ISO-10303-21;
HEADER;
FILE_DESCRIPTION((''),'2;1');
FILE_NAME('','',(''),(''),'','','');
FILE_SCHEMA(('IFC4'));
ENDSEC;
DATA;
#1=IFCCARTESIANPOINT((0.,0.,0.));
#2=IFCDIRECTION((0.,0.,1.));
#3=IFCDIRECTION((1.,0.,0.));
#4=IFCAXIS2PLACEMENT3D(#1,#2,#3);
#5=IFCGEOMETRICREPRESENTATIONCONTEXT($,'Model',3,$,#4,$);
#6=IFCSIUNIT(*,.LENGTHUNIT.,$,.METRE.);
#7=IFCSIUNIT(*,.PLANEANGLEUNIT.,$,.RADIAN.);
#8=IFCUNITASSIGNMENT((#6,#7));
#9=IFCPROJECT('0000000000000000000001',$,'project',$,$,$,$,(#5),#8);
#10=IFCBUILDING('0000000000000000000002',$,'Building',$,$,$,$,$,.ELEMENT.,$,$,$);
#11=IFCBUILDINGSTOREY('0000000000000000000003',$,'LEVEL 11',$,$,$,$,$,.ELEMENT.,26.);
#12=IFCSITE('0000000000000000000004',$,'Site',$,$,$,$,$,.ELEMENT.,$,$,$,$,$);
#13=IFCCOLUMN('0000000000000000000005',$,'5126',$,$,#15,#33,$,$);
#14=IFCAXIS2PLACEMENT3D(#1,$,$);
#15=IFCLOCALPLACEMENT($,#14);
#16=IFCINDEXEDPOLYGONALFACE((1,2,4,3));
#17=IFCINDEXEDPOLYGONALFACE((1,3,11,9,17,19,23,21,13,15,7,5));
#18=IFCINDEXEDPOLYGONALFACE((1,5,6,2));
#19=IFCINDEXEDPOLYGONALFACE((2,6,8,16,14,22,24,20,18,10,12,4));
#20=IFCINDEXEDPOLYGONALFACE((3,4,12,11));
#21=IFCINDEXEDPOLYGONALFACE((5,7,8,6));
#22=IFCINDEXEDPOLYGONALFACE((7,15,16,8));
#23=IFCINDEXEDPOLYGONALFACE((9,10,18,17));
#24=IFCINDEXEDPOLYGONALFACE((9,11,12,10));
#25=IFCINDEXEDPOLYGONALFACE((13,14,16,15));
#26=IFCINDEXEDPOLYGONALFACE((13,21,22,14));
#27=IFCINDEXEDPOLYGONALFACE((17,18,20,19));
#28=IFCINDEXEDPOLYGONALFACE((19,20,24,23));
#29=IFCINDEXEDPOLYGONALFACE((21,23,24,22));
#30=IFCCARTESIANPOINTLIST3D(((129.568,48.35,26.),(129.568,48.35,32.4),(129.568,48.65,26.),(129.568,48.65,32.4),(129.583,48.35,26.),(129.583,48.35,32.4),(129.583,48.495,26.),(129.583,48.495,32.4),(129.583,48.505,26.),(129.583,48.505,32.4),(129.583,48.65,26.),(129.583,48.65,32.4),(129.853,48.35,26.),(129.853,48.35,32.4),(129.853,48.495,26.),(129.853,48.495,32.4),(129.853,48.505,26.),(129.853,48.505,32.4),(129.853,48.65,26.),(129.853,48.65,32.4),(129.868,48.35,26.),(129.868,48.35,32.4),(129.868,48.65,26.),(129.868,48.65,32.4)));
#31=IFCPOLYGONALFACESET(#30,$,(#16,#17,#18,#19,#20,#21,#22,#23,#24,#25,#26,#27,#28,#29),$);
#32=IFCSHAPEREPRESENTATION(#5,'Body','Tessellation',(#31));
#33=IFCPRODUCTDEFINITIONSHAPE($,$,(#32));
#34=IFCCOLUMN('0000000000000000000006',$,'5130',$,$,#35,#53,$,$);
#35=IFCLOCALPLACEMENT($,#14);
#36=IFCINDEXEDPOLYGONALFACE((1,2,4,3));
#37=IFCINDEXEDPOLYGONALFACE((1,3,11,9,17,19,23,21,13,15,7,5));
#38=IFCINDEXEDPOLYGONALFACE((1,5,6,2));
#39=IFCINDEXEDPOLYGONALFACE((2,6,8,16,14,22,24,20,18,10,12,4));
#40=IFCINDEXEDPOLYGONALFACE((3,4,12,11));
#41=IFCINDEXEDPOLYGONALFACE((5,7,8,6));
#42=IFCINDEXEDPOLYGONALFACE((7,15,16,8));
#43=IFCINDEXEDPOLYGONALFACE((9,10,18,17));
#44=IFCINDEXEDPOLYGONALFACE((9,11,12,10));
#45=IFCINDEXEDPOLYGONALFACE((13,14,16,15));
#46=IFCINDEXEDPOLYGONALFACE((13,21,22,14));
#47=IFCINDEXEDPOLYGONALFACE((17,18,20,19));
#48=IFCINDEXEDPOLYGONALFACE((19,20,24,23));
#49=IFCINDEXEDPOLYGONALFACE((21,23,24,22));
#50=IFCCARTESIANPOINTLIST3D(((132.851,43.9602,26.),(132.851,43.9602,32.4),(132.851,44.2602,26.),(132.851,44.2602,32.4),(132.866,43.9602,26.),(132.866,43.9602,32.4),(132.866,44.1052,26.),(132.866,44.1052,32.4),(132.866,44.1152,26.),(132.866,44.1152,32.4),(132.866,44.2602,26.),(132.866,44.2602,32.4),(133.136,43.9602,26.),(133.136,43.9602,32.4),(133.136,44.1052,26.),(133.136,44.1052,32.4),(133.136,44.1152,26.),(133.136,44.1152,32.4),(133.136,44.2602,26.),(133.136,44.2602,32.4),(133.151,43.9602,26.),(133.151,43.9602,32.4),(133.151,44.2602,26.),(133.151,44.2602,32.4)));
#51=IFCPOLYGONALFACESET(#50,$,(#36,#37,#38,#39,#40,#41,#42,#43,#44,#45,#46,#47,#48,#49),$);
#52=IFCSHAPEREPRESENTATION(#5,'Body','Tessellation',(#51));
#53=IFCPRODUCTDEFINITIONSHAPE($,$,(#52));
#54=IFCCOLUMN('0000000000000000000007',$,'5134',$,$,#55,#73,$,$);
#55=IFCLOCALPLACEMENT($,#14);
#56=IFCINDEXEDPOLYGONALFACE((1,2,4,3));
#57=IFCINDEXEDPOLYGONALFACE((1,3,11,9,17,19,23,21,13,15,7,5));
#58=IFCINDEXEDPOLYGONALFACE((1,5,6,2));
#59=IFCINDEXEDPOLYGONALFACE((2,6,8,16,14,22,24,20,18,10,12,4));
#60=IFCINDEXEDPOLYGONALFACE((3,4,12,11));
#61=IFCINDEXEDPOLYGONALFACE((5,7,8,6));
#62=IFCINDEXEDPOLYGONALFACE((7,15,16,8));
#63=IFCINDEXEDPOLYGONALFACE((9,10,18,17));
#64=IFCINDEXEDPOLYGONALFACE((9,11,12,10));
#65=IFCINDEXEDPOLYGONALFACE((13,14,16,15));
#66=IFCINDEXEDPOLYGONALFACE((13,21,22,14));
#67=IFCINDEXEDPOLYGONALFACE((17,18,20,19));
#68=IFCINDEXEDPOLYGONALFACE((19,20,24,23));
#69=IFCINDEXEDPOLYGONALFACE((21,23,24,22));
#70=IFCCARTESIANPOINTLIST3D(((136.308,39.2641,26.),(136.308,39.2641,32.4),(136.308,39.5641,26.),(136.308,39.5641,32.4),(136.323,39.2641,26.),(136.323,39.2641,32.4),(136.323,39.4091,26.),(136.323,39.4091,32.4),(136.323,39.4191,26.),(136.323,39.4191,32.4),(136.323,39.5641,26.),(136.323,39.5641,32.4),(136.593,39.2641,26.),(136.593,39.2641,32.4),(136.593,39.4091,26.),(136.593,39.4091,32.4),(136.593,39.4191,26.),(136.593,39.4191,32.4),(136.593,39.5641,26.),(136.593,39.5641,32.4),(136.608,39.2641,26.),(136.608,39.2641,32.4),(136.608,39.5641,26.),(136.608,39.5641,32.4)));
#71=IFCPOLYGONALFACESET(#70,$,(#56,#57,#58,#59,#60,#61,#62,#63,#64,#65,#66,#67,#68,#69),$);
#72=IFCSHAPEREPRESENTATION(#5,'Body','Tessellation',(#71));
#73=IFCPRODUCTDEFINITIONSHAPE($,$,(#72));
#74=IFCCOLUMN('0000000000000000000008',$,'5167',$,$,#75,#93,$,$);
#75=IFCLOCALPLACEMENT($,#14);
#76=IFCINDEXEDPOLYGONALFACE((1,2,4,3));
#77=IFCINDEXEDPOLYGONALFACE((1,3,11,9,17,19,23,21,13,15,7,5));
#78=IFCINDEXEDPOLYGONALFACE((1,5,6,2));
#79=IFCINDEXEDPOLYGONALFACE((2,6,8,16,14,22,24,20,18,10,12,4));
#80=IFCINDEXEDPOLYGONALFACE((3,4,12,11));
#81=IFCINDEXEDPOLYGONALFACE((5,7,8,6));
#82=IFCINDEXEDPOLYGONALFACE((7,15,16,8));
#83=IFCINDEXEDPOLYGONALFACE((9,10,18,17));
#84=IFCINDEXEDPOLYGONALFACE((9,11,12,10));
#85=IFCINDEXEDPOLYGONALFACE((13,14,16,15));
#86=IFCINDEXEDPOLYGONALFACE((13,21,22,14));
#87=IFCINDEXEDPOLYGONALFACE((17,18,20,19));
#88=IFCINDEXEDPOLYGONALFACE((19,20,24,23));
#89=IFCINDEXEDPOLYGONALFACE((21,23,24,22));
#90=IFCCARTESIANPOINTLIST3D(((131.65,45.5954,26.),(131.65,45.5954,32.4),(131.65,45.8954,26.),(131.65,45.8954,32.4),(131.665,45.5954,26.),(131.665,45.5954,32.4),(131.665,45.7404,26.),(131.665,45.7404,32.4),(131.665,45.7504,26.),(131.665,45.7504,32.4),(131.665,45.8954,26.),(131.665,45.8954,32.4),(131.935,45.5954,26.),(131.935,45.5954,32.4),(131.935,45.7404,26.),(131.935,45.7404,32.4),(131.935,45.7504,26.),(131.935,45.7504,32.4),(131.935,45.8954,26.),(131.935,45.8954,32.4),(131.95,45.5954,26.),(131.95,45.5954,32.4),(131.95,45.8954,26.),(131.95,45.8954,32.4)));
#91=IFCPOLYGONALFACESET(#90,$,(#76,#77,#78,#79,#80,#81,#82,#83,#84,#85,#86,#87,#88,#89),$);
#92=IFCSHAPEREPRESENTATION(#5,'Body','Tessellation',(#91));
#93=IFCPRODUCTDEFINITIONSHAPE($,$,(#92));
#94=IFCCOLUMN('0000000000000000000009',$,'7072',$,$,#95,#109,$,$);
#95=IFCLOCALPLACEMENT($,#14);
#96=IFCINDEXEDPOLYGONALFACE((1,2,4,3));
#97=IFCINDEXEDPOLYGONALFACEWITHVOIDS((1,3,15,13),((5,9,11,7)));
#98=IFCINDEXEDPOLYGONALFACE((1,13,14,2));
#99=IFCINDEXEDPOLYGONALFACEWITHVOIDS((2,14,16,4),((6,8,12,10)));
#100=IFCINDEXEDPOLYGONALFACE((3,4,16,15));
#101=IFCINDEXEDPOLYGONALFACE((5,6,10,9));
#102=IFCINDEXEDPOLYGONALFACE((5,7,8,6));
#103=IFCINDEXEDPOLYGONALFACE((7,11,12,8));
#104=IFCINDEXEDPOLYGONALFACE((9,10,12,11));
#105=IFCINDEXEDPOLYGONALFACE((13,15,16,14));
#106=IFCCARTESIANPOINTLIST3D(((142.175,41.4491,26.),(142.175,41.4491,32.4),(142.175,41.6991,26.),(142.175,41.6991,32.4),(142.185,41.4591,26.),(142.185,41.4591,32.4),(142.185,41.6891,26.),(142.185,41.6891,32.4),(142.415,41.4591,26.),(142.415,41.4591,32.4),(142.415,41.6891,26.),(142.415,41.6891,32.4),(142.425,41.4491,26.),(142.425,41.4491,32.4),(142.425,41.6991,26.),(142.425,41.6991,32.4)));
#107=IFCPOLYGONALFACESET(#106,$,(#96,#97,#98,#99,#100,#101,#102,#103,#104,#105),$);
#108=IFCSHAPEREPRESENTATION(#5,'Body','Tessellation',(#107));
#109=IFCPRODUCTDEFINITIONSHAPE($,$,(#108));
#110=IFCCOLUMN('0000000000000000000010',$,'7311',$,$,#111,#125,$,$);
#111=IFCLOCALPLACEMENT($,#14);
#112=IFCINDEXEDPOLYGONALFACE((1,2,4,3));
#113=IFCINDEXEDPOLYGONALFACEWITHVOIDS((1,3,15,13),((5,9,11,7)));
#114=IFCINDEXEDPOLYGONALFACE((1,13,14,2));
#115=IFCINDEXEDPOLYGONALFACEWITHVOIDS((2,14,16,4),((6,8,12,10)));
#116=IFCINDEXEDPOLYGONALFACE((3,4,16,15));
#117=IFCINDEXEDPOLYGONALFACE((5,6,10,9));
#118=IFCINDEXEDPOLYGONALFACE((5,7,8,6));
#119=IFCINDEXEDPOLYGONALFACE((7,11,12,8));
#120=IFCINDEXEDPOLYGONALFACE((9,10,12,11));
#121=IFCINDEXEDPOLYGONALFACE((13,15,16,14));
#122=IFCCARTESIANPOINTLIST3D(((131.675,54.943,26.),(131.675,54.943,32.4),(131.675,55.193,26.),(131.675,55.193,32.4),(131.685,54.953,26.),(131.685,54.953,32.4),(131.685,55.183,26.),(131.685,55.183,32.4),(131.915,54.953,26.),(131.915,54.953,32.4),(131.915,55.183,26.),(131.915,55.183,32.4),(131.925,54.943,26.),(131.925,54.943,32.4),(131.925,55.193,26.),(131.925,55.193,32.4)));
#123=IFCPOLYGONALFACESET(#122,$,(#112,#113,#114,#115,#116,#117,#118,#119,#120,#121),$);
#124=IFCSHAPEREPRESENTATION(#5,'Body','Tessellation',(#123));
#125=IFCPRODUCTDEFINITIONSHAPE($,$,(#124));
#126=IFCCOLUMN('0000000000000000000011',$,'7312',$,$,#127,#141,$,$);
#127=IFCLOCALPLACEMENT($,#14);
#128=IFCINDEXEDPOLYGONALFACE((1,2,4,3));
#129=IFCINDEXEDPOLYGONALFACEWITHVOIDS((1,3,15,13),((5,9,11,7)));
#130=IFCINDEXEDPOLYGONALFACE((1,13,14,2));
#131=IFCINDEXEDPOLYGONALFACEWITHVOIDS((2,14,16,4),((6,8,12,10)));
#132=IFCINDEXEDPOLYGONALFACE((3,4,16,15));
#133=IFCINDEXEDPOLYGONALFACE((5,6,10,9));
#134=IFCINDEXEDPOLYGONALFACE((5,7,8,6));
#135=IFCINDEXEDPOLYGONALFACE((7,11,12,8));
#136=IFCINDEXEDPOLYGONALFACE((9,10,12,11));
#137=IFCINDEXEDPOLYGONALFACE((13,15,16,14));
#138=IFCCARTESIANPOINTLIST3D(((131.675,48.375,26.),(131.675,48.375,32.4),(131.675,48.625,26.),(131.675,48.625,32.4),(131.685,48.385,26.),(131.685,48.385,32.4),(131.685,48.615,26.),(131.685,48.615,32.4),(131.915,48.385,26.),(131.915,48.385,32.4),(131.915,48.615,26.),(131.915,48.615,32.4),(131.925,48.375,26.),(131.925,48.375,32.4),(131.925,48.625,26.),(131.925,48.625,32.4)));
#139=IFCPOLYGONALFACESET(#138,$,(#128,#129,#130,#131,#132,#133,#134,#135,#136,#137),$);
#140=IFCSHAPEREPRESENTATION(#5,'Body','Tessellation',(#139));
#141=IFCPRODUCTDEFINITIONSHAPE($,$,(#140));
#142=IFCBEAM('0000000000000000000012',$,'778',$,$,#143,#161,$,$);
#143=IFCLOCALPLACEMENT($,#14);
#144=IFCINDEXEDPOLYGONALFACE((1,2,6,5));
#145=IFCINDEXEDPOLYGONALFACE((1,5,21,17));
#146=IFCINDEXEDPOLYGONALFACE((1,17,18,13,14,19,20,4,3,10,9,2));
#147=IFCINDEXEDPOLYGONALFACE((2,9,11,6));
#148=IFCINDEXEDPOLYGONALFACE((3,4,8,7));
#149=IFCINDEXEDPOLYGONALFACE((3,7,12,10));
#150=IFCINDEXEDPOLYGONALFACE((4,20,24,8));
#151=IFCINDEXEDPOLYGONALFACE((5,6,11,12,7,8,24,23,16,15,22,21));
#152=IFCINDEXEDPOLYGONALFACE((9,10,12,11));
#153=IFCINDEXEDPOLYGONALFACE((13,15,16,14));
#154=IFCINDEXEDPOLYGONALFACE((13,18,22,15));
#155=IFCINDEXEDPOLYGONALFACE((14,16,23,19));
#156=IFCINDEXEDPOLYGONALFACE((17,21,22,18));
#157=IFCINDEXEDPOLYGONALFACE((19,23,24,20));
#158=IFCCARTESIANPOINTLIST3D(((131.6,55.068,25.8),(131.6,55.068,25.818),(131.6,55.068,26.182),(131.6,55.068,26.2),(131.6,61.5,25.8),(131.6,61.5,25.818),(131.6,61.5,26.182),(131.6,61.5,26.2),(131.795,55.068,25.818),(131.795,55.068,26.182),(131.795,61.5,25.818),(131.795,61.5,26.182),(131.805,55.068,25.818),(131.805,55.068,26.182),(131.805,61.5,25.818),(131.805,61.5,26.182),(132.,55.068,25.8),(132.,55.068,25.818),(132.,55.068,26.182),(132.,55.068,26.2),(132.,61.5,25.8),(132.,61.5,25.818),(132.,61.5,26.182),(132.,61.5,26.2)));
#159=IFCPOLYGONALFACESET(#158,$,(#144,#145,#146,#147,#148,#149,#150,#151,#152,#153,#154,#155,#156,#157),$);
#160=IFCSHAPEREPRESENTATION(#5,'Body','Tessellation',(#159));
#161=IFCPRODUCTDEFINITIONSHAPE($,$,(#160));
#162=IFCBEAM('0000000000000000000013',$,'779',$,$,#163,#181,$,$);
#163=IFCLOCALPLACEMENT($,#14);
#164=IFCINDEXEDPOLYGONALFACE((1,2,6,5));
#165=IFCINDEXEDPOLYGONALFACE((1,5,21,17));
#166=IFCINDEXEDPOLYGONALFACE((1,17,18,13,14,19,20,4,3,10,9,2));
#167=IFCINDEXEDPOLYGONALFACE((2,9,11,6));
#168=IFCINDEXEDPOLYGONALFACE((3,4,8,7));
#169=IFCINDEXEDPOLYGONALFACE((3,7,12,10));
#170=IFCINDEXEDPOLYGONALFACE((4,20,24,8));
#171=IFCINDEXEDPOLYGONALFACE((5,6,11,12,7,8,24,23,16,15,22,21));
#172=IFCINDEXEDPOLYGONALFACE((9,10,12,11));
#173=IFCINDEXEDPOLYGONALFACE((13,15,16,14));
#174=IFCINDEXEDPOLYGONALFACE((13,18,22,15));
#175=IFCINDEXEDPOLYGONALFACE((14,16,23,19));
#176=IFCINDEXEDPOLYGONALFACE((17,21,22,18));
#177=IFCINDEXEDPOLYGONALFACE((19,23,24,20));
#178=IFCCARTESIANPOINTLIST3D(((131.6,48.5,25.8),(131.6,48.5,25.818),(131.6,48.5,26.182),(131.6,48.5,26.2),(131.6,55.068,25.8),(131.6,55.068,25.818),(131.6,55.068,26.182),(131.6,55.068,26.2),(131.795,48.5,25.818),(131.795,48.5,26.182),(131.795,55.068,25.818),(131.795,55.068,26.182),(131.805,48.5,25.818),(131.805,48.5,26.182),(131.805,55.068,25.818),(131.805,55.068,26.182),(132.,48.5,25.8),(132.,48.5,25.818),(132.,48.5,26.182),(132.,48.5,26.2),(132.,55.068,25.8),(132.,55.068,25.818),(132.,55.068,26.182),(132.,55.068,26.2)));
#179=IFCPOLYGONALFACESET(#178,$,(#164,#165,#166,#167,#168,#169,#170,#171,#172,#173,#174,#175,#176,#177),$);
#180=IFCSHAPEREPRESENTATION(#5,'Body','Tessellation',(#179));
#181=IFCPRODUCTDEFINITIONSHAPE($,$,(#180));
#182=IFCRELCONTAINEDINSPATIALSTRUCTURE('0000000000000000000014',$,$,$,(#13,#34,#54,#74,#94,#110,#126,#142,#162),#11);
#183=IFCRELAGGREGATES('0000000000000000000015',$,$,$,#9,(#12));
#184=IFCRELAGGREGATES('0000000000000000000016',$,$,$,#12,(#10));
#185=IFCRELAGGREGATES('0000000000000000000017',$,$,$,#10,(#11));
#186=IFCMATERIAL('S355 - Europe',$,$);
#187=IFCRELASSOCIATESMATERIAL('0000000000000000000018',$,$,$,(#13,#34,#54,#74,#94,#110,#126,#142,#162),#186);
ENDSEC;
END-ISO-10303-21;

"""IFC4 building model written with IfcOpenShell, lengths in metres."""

from ifc_helpers import new_model, si_unit, frame, origin_with_axes, origin_2d_with_axis, place, context, project, spatial, hollow_rectangle, i_section, extrude, material, material_profile, profile_set, profile_usage, element, save


model = new_model("IFC4")

# Units and contexts
model_context = context("Model", 3, world=origin_with_axes())
ifc_project = project(units=[si_unit("LENGTHUNIT", "METRE"), si_unit("PLANEANGLEUNIT", "RADIAN")], contexts=[model_context])

# Site, building, storey
site = spatial("IfcSite", under=ifc_project, Name="Site", CompositionType="ELEMENT")
building = spatial("IfcBuilding", under=site, Name="Building", CompositionType="ELEMENT")
storey = spatial("IfcBuildingStorey", under=building, Name="LEVEL 11", CompositionType="ELEMENT", Elevation=26.0)

# Columns
ifc_material = material(Name="S355 - Europe")
ifc_material_profile_1 = material_profile(ifc_material, i_section(OverallWidth=0.3, OverallDepth=0.3, WebThickness=0.01, FlangeThickness=0.015, at=origin_2d_with_axis()))
ifc_profile_set_1 = profile_set([ifc_material_profile_1])
ifc_profile_usage_1 = profile_usage(ifc_profile_set_1, cardinal=10)
column_1_placement = place(None, frame((129.718, 48.5, 26.0), z_axis=(0.0, 0.0, 1.0), x_axis=(0.0, -1.0, 0.0)))
element("IfcColumn", 1, at=column_1_placement, inside=storey, material=ifc_profile_usage_1, Name="5126", context=model_context, shape_type="SweptSolid", body=[
    extrude(i_section(OverallWidth=0.3, OverallDepth=0.3, WebThickness=0.01, FlangeThickness=0.015, at=origin_2d_with_axis()), origin_with_axes(), (0.0, 0.0, 1.0), 6.4),
])
ifc_material_profile_2 = material_profile(ifc_material, i_section(OverallWidth=0.3, OverallDepth=0.3, WebThickness=0.01, FlangeThickness=0.015, at=origin_2d_with_axis()))
ifc_profile_set_2 = profile_set([ifc_material_profile_2])
ifc_profile_usage_2 = profile_usage(ifc_profile_set_2, cardinal=10)
column_2_placement = place(None, frame((133.001, 44.1102, 26.0), z_axis=(0.0, 0.0, 1.0), x_axis=(0.0, -1.0, 0.0)))
element("IfcColumn", 2, at=column_2_placement, inside=storey, material=ifc_profile_usage_2, Name="5130", context=model_context, shape_type="SweptSolid", body=[
    extrude(i_section(OverallWidth=0.3, OverallDepth=0.3, WebThickness=0.01, FlangeThickness=0.015, at=origin_2d_with_axis()), origin_with_axes(), (0.0, 0.0, 1.0), 6.4),
])
ifc_material_profile_3 = material_profile(ifc_material, i_section(OverallWidth=0.3, OverallDepth=0.3, WebThickness=0.01, FlangeThickness=0.015, at=origin_2d_with_axis()))
ifc_profile_set_3 = profile_set([ifc_material_profile_3])
ifc_profile_usage_3 = profile_usage(ifc_profile_set_3, cardinal=10)
column_3_placement = place(None, frame((136.458, 39.4141, 26.0), z_axis=(0.0, 0.0, 1.0), x_axis=(0.0, -1.0, 0.0)))
element("IfcColumn", 3, at=column_3_placement, inside=storey, material=ifc_profile_usage_3, Name="5134", context=model_context, shape_type="SweptSolid", body=[
    extrude(i_section(OverallWidth=0.3, OverallDepth=0.3, WebThickness=0.01, FlangeThickness=0.015, at=origin_2d_with_axis()), origin_with_axes(), (0.0, 0.0, 1.0), 6.4),
])
ifc_material_profile_4 = material_profile(ifc_material, i_section(OverallWidth=0.3, OverallDepth=0.3, WebThickness=0.01, FlangeThickness=0.015, at=origin_2d_with_axis()))
ifc_profile_set_4 = profile_set([ifc_material_profile_4])
ifc_profile_usage_4 = profile_usage(ifc_profile_set_4, cardinal=10)
column_4_placement = place(None, frame((131.8, 45.7454, 26.0), z_axis=(0.0, 0.0, 1.0), x_axis=(0.0, -1.0, 0.0)))
element("IfcColumn", 4, at=column_4_placement, inside=storey, material=ifc_profile_usage_4, Name="5167", context=model_context, shape_type="SweptSolid", body=[
    extrude(i_section(OverallWidth=0.3, OverallDepth=0.3, WebThickness=0.01, FlangeThickness=0.015, at=origin_2d_with_axis()), origin_with_axes(), (0.0, 0.0, 1.0), 6.4),
])
ifc_material_profile_5 = material_profile(ifc_material, hollow_rectangle(XDim=0.25, YDim=0.25, WallThickness=0.01, at=origin_2d_with_axis()))
ifc_profile_set_5 = profile_set([ifc_material_profile_5])
ifc_profile_usage_5 = profile_usage(ifc_profile_set_5, cardinal=10)
column_5_placement = place(None, frame((142.3, 41.5741, 26.0), z_axis=(0.0, 0.0, 1.0), x_axis=(0.0, -1.0, 0.0)))
element("IfcColumn", 5, at=column_5_placement, inside=storey, material=ifc_profile_usage_5, Name="7072", context=model_context, shape_type="SweptSolid", body=[
    extrude(hollow_rectangle(XDim=0.25, YDim=0.25, WallThickness=0.01, at=origin_2d_with_axis()), origin_with_axes(), (0.0, 0.0, 1.0), 6.4),
])
ifc_material_profile_6 = material_profile(ifc_material, hollow_rectangle(XDim=0.25, YDim=0.25, WallThickness=0.01, at=origin_2d_with_axis()))
ifc_profile_set_6 = profile_set([ifc_material_profile_6])
ifc_profile_usage_6 = profile_usage(ifc_profile_set_6, cardinal=10)
column_6_placement = place(None, frame((131.8, 55.068, 32.4), z_axis=(0.0, 0.0, -1.0), x_axis=(0.0, 1.0, 0.0)))
element("IfcColumn", 6, at=column_6_placement, inside=storey, material=ifc_profile_usage_6, Name="7311", context=model_context, shape_type="SweptSolid", body=[
    extrude(hollow_rectangle(XDim=0.25, YDim=0.25, WallThickness=0.01, at=origin_2d_with_axis()), origin_with_axes(), (0.0, 0.0, 1.0), 6.4),
])
ifc_material_profile_7 = material_profile(ifc_material, hollow_rectangle(XDim=0.25, YDim=0.25, WallThickness=0.01, at=origin_2d_with_axis()))
ifc_profile_set_7 = profile_set([ifc_material_profile_7])
ifc_profile_usage_7 = profile_usage(ifc_profile_set_7, cardinal=10)
column_7_placement = place(None, frame((131.8, 48.5, 26.0), z_axis=(0.0, 0.0, 1.0), x_axis=(0.0, -1.0, 0.0)))
element("IfcColumn", 7, at=column_7_placement, inside=storey, material=ifc_profile_usage_7, Name="7312", context=model_context, shape_type="SweptSolid", body=[
    extrude(hollow_rectangle(XDim=0.25, YDim=0.25, WallThickness=0.01, at=origin_2d_with_axis()), origin_with_axes(), (0.0, 0.0, 1.0), 6.4),
])

# Beams
ifc_material_profile_8 = material_profile(ifc_material, i_section(OverallWidth=0.4, OverallDepth=0.4, WebThickness=0.01, FlangeThickness=0.018, at=origin_2d_with_axis()))
ifc_profile_set_8 = profile_set([ifc_material_profile_8])
ifc_profile_usage_8 = profile_usage(ifc_profile_set_8, cardinal=10)
beam_1_placement = place(None, frame((131.8, 55.068, 26.0), z_axis=(0.0, 1.0, 0.0), x_axis=(-1.0, 0.0, 0.0)))
element("IfcBeam", 8, at=beam_1_placement, inside=storey, material=ifc_profile_usage_8, Name="778", context=model_context, shape_type="SweptSolid", body=[
    extrude(i_section(OverallWidth=0.4, OverallDepth=0.4, WebThickness=0.01, FlangeThickness=0.018, at=origin_2d_with_axis()), origin_with_axes(), (0.0, 0.0, 1.0), 6.432),
])
ifc_material_profile_9 = material_profile(ifc_material, i_section(OverallWidth=0.4, OverallDepth=0.4, WebThickness=0.01, FlangeThickness=0.018, at=origin_2d_with_axis()))
ifc_profile_set_9 = profile_set([ifc_material_profile_9])
ifc_profile_usage_9 = profile_usage(ifc_profile_set_9, cardinal=10)
beam_2_placement = place(None, frame((131.8, 48.5, 26.0), z_axis=(0.0, 1.0, 0.0), x_axis=(-1.0, 0.0, 0.0)))
element("IfcBeam", 9, at=beam_2_placement, inside=storey, material=ifc_profile_usage_9, Name="779", context=model_context, shape_type="SweptSolid", body=[
    extrude(i_section(OverallWidth=0.4, OverallDepth=0.4, WebThickness=0.01, FlangeThickness=0.018, at=origin_2d_with_axis()), origin_with_axes(), (0.0, 0.0, 1.0), 6.568),
])

save(model, "model.ifc")
